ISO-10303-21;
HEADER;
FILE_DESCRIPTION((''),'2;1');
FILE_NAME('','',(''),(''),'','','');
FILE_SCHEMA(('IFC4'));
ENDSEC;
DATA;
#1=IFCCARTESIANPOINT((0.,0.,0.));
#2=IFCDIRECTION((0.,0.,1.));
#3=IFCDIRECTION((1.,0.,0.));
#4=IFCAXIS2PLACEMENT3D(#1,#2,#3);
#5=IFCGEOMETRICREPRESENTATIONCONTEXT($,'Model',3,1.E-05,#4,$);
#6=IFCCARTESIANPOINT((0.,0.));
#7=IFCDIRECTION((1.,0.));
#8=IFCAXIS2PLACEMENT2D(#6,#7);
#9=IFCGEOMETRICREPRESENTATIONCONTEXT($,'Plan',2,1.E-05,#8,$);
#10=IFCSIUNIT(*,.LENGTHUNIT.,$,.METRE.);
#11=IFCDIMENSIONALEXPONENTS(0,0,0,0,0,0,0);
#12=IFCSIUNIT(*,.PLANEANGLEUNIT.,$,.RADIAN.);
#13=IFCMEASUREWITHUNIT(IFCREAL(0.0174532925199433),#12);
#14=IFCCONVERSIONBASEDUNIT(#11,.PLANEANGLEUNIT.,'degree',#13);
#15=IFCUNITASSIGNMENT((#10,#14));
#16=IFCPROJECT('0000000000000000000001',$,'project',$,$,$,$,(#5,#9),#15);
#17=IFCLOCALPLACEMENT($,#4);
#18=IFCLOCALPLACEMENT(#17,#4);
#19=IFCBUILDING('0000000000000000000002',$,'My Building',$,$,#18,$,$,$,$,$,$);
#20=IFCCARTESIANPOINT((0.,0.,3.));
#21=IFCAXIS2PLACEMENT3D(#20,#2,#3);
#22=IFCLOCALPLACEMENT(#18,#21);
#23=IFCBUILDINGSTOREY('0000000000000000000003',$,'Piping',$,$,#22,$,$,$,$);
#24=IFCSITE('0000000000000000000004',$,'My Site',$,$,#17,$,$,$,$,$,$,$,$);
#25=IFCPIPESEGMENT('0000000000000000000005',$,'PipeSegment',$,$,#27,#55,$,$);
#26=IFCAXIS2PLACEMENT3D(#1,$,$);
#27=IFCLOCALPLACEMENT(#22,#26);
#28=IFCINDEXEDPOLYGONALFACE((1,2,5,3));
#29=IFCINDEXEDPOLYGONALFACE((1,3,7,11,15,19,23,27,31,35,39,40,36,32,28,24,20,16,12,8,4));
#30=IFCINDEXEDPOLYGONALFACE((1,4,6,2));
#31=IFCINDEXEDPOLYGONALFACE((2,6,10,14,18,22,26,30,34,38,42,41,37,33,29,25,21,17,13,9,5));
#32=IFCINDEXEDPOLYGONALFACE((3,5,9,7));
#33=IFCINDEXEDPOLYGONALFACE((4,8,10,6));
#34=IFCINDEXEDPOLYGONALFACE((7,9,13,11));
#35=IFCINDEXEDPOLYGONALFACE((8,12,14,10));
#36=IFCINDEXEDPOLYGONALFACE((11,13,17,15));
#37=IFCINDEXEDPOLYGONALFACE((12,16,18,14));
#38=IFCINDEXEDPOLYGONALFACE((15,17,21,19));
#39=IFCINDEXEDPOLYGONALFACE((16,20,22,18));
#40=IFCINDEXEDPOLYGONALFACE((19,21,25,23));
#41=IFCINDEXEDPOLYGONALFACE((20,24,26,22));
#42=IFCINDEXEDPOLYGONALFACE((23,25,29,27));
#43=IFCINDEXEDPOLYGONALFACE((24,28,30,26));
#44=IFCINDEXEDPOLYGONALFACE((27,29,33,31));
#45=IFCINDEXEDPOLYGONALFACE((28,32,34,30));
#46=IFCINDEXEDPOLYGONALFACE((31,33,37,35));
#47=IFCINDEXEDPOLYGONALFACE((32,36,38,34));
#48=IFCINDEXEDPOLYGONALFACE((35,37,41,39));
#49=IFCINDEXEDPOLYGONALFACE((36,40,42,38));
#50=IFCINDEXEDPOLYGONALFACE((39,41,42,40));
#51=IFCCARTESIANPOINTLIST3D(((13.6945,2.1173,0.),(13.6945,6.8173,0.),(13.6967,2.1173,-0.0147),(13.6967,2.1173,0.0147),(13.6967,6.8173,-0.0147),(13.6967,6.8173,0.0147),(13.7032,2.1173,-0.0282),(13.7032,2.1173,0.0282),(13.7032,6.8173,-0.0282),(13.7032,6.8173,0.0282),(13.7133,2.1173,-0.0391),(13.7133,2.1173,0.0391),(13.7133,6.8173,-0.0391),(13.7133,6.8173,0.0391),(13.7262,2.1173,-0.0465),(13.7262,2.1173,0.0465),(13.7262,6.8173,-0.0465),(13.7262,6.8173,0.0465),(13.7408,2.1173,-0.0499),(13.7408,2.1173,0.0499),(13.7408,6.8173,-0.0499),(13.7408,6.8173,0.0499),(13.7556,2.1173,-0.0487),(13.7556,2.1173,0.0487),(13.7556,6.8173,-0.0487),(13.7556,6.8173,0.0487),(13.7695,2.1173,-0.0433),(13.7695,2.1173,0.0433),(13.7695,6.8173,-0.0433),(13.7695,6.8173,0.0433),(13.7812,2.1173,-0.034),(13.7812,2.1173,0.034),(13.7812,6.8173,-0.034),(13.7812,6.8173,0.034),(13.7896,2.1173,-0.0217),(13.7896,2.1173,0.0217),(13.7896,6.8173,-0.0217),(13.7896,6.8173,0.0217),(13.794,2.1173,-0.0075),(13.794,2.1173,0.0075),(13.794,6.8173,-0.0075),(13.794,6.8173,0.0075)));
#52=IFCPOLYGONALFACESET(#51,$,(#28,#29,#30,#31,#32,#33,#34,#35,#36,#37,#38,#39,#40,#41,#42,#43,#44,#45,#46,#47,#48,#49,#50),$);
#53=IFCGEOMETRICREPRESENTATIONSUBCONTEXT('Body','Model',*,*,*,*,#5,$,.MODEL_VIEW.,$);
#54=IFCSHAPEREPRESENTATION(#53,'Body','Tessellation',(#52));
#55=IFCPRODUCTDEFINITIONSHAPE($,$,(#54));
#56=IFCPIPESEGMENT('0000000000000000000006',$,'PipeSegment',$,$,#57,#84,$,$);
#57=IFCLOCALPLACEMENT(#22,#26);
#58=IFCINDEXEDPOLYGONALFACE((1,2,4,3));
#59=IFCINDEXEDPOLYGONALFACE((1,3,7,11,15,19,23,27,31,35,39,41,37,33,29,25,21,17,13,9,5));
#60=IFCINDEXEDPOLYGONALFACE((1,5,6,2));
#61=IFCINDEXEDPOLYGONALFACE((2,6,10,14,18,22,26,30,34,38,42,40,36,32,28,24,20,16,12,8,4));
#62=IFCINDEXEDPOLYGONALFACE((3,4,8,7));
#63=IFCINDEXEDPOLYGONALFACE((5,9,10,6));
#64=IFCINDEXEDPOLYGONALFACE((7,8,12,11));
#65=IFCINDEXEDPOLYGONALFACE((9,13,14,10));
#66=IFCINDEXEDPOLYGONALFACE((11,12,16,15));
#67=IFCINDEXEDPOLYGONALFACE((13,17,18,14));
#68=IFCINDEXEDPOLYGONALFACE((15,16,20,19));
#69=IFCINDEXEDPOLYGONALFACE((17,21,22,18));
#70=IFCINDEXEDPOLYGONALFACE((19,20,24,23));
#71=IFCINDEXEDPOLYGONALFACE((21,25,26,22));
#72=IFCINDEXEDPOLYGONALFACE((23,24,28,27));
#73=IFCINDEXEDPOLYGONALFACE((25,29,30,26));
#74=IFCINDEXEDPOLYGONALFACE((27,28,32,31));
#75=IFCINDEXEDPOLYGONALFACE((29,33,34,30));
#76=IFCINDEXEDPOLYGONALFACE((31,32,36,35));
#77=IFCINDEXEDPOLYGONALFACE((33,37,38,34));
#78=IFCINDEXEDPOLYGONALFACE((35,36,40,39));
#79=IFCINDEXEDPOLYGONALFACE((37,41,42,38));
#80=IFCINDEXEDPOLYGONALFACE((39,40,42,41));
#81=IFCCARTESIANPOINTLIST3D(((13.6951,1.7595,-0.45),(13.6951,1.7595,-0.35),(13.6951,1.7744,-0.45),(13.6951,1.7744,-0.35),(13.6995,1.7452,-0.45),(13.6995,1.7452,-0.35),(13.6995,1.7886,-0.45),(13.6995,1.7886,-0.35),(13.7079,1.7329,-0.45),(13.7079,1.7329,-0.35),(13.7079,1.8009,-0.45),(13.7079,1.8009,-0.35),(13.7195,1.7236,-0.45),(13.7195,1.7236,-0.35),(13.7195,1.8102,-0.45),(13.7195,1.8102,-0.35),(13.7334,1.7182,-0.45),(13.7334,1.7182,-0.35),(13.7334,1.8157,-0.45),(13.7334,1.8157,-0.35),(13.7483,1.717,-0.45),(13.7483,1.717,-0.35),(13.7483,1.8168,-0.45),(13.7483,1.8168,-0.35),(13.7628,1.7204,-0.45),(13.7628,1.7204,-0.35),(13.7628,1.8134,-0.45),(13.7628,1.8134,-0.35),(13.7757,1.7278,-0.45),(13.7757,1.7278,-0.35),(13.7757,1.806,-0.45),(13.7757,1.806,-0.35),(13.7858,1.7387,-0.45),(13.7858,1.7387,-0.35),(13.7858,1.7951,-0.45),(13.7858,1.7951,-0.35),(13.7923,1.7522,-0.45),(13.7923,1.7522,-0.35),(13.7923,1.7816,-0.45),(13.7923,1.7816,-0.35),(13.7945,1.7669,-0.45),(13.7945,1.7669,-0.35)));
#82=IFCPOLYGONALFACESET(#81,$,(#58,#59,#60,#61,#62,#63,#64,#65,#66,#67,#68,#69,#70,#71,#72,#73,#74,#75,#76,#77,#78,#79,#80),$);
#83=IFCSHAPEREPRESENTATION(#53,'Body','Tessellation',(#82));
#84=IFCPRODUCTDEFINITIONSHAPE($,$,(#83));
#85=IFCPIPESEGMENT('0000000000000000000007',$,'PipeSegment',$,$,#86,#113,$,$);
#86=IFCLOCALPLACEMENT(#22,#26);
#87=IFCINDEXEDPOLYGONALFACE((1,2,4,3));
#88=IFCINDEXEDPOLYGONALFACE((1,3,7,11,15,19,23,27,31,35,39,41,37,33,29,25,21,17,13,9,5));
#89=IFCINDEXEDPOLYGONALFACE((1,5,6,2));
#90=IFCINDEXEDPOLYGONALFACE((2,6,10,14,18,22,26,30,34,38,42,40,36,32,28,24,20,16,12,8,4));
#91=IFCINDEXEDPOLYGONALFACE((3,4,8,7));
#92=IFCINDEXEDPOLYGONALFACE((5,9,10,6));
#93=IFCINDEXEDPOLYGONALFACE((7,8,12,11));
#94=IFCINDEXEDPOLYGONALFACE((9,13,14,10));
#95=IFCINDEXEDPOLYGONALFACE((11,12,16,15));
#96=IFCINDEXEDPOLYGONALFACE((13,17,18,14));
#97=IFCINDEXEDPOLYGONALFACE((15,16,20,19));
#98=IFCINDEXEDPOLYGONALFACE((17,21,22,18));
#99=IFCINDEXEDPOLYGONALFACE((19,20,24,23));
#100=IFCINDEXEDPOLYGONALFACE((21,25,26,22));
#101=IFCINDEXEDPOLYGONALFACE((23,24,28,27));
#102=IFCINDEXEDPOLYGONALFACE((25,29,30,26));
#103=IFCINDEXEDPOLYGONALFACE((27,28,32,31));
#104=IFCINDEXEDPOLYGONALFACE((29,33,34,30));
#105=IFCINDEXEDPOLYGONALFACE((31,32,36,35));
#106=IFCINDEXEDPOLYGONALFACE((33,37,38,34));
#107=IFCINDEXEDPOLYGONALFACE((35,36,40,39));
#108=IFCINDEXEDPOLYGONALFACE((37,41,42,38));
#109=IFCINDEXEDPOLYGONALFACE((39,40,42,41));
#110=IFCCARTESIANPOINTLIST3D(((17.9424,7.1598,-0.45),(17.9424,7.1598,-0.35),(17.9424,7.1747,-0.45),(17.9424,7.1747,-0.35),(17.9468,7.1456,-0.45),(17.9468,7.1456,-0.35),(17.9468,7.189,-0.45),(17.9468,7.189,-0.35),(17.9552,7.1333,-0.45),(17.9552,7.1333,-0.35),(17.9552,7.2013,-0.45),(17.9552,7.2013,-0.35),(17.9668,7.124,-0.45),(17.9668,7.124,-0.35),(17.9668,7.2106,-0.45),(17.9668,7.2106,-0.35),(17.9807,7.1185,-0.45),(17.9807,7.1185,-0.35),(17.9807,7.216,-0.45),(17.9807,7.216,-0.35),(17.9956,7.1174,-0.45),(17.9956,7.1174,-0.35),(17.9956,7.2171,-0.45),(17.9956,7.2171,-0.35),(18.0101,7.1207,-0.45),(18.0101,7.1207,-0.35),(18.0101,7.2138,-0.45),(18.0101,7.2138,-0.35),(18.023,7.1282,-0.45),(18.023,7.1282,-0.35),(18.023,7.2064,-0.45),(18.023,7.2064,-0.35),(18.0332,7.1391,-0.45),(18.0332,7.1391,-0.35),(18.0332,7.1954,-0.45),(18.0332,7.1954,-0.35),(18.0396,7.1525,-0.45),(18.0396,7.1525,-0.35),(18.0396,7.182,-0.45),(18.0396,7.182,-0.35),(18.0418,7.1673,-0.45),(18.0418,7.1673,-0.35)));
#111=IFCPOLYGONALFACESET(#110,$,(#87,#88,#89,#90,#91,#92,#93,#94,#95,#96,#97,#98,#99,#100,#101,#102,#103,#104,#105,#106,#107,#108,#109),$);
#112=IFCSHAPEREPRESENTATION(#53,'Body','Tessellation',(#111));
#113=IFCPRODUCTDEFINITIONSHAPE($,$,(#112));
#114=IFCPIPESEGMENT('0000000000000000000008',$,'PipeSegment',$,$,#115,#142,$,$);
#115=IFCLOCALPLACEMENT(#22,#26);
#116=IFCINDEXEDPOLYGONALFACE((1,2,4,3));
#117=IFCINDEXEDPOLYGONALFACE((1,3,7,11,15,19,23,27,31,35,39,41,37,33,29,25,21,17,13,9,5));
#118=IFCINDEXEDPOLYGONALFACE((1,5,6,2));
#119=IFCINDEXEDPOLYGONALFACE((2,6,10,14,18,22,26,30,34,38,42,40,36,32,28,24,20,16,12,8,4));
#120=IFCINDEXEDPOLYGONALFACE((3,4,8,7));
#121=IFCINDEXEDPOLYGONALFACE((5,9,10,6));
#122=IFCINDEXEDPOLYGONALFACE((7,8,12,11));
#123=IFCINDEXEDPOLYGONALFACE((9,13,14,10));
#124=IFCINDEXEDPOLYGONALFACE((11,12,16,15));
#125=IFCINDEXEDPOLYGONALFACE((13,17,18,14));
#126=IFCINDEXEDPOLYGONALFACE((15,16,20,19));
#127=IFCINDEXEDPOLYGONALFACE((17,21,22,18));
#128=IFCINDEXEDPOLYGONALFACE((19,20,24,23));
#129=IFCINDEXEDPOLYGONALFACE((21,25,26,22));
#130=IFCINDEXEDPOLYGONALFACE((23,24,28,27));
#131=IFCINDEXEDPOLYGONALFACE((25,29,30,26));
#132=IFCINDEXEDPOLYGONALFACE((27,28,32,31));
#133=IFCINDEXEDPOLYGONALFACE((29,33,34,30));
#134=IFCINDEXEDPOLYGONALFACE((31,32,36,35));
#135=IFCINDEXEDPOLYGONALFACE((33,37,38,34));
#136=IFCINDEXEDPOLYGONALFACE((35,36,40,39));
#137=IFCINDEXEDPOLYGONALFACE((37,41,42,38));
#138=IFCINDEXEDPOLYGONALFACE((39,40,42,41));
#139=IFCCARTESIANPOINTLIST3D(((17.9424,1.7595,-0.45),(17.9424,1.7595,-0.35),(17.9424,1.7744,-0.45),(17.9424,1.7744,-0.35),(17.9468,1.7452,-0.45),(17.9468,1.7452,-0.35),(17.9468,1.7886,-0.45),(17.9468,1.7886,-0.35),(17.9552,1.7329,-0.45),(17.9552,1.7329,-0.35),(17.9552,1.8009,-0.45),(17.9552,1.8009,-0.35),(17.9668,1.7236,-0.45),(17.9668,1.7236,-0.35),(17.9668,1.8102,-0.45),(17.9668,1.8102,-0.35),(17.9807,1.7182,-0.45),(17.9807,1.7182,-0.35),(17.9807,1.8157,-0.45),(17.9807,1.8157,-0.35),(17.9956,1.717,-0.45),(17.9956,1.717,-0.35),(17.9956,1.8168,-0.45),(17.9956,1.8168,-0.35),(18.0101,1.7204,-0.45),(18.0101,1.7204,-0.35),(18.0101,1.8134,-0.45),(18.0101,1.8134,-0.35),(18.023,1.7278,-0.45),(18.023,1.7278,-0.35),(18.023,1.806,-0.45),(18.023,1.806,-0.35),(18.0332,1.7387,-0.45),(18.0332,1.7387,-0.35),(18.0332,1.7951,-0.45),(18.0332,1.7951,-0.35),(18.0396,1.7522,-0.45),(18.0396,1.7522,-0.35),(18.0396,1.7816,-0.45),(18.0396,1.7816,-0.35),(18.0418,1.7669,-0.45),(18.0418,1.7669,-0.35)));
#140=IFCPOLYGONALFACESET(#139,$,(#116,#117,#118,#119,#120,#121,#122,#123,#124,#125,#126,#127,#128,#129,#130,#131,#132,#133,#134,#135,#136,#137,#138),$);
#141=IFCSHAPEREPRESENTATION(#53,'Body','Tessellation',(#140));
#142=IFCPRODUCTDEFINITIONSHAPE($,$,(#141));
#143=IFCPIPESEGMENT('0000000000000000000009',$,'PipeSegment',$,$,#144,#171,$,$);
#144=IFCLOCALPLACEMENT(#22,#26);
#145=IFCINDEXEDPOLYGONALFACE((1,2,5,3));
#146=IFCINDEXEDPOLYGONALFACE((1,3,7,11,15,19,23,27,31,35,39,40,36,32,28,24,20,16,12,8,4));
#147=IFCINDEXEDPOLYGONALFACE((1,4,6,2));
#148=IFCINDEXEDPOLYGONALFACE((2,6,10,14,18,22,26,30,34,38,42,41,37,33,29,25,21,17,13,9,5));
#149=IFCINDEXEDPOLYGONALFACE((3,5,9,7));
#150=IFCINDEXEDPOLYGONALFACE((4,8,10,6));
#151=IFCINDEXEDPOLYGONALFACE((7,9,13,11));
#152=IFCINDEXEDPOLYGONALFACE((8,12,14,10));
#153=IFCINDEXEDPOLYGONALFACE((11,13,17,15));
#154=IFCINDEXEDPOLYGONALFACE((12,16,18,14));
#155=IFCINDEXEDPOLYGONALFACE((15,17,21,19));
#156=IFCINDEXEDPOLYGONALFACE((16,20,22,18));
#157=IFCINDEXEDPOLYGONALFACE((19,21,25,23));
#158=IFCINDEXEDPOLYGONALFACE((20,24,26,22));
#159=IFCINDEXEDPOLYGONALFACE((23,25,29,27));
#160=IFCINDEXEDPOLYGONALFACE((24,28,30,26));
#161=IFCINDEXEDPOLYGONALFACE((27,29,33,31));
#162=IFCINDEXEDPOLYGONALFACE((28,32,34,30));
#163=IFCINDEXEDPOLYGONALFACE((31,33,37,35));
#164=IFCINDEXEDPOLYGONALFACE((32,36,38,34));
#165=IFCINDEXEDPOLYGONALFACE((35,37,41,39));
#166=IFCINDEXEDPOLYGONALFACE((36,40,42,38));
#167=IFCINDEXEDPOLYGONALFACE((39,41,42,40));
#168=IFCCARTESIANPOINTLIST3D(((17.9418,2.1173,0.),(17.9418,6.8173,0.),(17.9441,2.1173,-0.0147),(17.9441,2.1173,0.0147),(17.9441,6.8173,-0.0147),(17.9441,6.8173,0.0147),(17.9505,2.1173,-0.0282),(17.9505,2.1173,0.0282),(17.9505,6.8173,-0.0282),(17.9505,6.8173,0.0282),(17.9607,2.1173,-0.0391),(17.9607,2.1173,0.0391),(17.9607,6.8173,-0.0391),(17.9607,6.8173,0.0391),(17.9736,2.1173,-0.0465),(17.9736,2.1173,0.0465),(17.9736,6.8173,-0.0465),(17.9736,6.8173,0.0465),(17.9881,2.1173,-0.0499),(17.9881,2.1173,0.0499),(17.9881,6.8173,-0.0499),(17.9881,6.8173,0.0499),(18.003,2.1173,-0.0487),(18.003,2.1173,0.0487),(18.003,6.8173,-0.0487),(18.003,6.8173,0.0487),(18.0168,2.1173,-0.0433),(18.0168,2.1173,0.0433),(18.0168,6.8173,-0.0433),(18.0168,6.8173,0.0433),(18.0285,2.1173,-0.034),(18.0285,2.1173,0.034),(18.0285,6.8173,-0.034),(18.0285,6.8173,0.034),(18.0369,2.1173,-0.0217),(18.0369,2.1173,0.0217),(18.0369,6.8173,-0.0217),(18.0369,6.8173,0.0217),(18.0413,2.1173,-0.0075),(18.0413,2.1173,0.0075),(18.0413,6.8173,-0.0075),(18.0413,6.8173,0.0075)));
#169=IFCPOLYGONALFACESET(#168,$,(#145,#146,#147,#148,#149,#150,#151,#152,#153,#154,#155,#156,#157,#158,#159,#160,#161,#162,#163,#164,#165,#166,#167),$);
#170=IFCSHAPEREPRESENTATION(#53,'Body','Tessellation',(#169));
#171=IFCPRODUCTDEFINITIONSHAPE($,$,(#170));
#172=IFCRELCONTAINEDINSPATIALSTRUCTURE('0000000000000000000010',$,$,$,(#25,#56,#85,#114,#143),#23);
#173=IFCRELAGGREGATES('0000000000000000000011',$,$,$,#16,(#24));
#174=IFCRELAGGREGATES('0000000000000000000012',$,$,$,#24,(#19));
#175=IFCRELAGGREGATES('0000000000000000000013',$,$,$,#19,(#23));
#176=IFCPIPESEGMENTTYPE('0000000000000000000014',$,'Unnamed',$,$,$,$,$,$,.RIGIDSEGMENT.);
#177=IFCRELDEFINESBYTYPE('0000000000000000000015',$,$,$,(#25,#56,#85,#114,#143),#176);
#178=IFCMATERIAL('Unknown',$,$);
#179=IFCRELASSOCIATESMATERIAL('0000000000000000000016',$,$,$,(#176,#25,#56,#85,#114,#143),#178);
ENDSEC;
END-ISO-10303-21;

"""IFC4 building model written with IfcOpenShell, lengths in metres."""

from ifc_helpers import new_model, entity, si_unit, converted_unit, frame, origin_with_axes, origin_2d_with_axis, place, context, subcontext, project, spatial, circle, extrude, material, material_profile, profile_set, profile_usage, type_object, element, save


model = new_model("IFC4")

# Units and contexts
model_context = context("Model", 3, precision=1e-05, world=origin_with_axes())
plan_context = context("Plan", 2, precision=1e-05, world=origin_2d_with_axis())
body_context = subcontext(model_context, "Body", "Model", "MODEL_VIEW")
ifc_project = project(units=[si_unit("LENGTHUNIT", "METRE"), converted_unit("PLANEANGLEUNIT", "degree", entity("IfcReal", 0.0174532925199433), si_unit("PLANEANGLEUNIT", "RADIAN"), dimensions=[0, 0, 0, 0, 0, 0, 0])], contexts=[model_context, plan_context])

# Site, building, storey
site_placement = place(None, origin_with_axes())
site = spatial("IfcSite", under=ifc_project, at=site_placement, Name="My Site")
building_placement = place(site_placement, origin_with_axes())
building = spatial("IfcBuilding", under=site, at=building_placement, Name="My Building")
storey_placement = place(building_placement, frame((0.0, 0.0, 3.0), z_axis=(0.0, 0.0, 1.0), x_axis=(1.0, 0.0, 0.0)))
storey = spatial("IfcBuildingStorey", under=building, at=storey_placement, Name="Piping")

# Pipe segments
ifc_material = material(Name="Unknown")
ifc_material_profile = material_profile(ifc_material, circle(Radius=0.05))
ifc_profile_set = profile_set([ifc_material_profile])
pipe_segment_type = type_object("IfcPipeSegmentType", Name="Unnamed", PredefinedType="RIGIDSEGMENT", material=ifc_profile_set)
ifc_profile_usage_1 = profile_usage(ifc_profile_set, cardinal=5)
pipe_segment_1_placement = place(storey_placement, frame((13.7445, 2.1173, 0.0), z_axis=(0.0, 1.0, 0.0), x_axis=(-1.0, 0.0, 0.0)))
element("IfcPipeSegment", 1, at=pipe_segment_1_placement, inside=storey, type_object=pipe_segment_type, material=ifc_profile_usage_1, Name="PipeSegment", context=body_context, shape_type="SweptSolid", body=[
    extrude(circle(Radius=0.05), origin_with_axes(), (0.0, 0.0, 1.0), 4.7),
])
ifc_profile_usage_2 = profile_usage(ifc_profile_set, cardinal=5)
pipe_segment_2_placement = place(storey_placement, frame((13.7445, 1.7669, -0.35), z_axis=(0.0, 0.0, -1.0), x_axis=(1.0, 0.0, 0.0)))
element("IfcPipeSegment", 2, at=pipe_segment_2_placement, inside=storey, type_object=pipe_segment_type, material=ifc_profile_usage_2, Name="PipeSegment", context=body_context, shape_type="SweptSolid", body=[
    extrude(circle(Radius=0.05), origin_with_axes(), (0.0, 0.0, 1.0), 0.1),
])
ifc_profile_usage_3 = profile_usage(ifc_profile_set, cardinal=5)
pipe_segment_3_placement = place(storey_placement, frame((17.9918, 7.1673, -0.35), z_axis=(0.0, 0.0, -1.0), x_axis=(1.0, 0.0, 0.0)))
element("IfcPipeSegment", 3, at=pipe_segment_3_placement, inside=storey, type_object=pipe_segment_type, material=ifc_profile_usage_3, Name="PipeSegment", context=body_context, shape_type="SweptSolid", body=[
    extrude(circle(Radius=0.05), origin_with_axes(), (0.0, 0.0, 1.0), 0.1),
])
ifc_profile_usage_4 = profile_usage(ifc_profile_set, cardinal=5)
pipe_segment_4_placement = place(storey_placement, frame((17.9918, 1.7669, -0.35), z_axis=(0.0, 0.0, -1.0), x_axis=(1.0, 0.0, 0.0)))
element("IfcPipeSegment", 4, at=pipe_segment_4_placement, inside=storey, type_object=pipe_segment_type, material=ifc_profile_usage_4, Name="PipeSegment", context=body_context, shape_type="SweptSolid", body=[
    extrude(circle(Radius=0.05), origin_with_axes(), (0.0, 0.0, 1.0), 0.1),
])
ifc_profile_usage_5 = profile_usage(ifc_profile_set, cardinal=5)
pipe_segment_5_placement = place(storey_placement, frame((17.9918, 2.1173, 0.0), z_axis=(0.0, 1.0, 0.0), x_axis=(-1.0, 0.0, 0.0)))
element("IfcPipeSegment", 5, at=pipe_segment_5_placement, inside=storey, type_object=pipe_segment_type, material=ifc_profile_usage_5, Name="PipeSegment", context=body_context, shape_type="SweptSolid", body=[
    extrude(circle(Radius=0.05), origin_with_axes(), (0.0, 0.0, 1.0), 4.7),
])

save(model, "model.ifc")
